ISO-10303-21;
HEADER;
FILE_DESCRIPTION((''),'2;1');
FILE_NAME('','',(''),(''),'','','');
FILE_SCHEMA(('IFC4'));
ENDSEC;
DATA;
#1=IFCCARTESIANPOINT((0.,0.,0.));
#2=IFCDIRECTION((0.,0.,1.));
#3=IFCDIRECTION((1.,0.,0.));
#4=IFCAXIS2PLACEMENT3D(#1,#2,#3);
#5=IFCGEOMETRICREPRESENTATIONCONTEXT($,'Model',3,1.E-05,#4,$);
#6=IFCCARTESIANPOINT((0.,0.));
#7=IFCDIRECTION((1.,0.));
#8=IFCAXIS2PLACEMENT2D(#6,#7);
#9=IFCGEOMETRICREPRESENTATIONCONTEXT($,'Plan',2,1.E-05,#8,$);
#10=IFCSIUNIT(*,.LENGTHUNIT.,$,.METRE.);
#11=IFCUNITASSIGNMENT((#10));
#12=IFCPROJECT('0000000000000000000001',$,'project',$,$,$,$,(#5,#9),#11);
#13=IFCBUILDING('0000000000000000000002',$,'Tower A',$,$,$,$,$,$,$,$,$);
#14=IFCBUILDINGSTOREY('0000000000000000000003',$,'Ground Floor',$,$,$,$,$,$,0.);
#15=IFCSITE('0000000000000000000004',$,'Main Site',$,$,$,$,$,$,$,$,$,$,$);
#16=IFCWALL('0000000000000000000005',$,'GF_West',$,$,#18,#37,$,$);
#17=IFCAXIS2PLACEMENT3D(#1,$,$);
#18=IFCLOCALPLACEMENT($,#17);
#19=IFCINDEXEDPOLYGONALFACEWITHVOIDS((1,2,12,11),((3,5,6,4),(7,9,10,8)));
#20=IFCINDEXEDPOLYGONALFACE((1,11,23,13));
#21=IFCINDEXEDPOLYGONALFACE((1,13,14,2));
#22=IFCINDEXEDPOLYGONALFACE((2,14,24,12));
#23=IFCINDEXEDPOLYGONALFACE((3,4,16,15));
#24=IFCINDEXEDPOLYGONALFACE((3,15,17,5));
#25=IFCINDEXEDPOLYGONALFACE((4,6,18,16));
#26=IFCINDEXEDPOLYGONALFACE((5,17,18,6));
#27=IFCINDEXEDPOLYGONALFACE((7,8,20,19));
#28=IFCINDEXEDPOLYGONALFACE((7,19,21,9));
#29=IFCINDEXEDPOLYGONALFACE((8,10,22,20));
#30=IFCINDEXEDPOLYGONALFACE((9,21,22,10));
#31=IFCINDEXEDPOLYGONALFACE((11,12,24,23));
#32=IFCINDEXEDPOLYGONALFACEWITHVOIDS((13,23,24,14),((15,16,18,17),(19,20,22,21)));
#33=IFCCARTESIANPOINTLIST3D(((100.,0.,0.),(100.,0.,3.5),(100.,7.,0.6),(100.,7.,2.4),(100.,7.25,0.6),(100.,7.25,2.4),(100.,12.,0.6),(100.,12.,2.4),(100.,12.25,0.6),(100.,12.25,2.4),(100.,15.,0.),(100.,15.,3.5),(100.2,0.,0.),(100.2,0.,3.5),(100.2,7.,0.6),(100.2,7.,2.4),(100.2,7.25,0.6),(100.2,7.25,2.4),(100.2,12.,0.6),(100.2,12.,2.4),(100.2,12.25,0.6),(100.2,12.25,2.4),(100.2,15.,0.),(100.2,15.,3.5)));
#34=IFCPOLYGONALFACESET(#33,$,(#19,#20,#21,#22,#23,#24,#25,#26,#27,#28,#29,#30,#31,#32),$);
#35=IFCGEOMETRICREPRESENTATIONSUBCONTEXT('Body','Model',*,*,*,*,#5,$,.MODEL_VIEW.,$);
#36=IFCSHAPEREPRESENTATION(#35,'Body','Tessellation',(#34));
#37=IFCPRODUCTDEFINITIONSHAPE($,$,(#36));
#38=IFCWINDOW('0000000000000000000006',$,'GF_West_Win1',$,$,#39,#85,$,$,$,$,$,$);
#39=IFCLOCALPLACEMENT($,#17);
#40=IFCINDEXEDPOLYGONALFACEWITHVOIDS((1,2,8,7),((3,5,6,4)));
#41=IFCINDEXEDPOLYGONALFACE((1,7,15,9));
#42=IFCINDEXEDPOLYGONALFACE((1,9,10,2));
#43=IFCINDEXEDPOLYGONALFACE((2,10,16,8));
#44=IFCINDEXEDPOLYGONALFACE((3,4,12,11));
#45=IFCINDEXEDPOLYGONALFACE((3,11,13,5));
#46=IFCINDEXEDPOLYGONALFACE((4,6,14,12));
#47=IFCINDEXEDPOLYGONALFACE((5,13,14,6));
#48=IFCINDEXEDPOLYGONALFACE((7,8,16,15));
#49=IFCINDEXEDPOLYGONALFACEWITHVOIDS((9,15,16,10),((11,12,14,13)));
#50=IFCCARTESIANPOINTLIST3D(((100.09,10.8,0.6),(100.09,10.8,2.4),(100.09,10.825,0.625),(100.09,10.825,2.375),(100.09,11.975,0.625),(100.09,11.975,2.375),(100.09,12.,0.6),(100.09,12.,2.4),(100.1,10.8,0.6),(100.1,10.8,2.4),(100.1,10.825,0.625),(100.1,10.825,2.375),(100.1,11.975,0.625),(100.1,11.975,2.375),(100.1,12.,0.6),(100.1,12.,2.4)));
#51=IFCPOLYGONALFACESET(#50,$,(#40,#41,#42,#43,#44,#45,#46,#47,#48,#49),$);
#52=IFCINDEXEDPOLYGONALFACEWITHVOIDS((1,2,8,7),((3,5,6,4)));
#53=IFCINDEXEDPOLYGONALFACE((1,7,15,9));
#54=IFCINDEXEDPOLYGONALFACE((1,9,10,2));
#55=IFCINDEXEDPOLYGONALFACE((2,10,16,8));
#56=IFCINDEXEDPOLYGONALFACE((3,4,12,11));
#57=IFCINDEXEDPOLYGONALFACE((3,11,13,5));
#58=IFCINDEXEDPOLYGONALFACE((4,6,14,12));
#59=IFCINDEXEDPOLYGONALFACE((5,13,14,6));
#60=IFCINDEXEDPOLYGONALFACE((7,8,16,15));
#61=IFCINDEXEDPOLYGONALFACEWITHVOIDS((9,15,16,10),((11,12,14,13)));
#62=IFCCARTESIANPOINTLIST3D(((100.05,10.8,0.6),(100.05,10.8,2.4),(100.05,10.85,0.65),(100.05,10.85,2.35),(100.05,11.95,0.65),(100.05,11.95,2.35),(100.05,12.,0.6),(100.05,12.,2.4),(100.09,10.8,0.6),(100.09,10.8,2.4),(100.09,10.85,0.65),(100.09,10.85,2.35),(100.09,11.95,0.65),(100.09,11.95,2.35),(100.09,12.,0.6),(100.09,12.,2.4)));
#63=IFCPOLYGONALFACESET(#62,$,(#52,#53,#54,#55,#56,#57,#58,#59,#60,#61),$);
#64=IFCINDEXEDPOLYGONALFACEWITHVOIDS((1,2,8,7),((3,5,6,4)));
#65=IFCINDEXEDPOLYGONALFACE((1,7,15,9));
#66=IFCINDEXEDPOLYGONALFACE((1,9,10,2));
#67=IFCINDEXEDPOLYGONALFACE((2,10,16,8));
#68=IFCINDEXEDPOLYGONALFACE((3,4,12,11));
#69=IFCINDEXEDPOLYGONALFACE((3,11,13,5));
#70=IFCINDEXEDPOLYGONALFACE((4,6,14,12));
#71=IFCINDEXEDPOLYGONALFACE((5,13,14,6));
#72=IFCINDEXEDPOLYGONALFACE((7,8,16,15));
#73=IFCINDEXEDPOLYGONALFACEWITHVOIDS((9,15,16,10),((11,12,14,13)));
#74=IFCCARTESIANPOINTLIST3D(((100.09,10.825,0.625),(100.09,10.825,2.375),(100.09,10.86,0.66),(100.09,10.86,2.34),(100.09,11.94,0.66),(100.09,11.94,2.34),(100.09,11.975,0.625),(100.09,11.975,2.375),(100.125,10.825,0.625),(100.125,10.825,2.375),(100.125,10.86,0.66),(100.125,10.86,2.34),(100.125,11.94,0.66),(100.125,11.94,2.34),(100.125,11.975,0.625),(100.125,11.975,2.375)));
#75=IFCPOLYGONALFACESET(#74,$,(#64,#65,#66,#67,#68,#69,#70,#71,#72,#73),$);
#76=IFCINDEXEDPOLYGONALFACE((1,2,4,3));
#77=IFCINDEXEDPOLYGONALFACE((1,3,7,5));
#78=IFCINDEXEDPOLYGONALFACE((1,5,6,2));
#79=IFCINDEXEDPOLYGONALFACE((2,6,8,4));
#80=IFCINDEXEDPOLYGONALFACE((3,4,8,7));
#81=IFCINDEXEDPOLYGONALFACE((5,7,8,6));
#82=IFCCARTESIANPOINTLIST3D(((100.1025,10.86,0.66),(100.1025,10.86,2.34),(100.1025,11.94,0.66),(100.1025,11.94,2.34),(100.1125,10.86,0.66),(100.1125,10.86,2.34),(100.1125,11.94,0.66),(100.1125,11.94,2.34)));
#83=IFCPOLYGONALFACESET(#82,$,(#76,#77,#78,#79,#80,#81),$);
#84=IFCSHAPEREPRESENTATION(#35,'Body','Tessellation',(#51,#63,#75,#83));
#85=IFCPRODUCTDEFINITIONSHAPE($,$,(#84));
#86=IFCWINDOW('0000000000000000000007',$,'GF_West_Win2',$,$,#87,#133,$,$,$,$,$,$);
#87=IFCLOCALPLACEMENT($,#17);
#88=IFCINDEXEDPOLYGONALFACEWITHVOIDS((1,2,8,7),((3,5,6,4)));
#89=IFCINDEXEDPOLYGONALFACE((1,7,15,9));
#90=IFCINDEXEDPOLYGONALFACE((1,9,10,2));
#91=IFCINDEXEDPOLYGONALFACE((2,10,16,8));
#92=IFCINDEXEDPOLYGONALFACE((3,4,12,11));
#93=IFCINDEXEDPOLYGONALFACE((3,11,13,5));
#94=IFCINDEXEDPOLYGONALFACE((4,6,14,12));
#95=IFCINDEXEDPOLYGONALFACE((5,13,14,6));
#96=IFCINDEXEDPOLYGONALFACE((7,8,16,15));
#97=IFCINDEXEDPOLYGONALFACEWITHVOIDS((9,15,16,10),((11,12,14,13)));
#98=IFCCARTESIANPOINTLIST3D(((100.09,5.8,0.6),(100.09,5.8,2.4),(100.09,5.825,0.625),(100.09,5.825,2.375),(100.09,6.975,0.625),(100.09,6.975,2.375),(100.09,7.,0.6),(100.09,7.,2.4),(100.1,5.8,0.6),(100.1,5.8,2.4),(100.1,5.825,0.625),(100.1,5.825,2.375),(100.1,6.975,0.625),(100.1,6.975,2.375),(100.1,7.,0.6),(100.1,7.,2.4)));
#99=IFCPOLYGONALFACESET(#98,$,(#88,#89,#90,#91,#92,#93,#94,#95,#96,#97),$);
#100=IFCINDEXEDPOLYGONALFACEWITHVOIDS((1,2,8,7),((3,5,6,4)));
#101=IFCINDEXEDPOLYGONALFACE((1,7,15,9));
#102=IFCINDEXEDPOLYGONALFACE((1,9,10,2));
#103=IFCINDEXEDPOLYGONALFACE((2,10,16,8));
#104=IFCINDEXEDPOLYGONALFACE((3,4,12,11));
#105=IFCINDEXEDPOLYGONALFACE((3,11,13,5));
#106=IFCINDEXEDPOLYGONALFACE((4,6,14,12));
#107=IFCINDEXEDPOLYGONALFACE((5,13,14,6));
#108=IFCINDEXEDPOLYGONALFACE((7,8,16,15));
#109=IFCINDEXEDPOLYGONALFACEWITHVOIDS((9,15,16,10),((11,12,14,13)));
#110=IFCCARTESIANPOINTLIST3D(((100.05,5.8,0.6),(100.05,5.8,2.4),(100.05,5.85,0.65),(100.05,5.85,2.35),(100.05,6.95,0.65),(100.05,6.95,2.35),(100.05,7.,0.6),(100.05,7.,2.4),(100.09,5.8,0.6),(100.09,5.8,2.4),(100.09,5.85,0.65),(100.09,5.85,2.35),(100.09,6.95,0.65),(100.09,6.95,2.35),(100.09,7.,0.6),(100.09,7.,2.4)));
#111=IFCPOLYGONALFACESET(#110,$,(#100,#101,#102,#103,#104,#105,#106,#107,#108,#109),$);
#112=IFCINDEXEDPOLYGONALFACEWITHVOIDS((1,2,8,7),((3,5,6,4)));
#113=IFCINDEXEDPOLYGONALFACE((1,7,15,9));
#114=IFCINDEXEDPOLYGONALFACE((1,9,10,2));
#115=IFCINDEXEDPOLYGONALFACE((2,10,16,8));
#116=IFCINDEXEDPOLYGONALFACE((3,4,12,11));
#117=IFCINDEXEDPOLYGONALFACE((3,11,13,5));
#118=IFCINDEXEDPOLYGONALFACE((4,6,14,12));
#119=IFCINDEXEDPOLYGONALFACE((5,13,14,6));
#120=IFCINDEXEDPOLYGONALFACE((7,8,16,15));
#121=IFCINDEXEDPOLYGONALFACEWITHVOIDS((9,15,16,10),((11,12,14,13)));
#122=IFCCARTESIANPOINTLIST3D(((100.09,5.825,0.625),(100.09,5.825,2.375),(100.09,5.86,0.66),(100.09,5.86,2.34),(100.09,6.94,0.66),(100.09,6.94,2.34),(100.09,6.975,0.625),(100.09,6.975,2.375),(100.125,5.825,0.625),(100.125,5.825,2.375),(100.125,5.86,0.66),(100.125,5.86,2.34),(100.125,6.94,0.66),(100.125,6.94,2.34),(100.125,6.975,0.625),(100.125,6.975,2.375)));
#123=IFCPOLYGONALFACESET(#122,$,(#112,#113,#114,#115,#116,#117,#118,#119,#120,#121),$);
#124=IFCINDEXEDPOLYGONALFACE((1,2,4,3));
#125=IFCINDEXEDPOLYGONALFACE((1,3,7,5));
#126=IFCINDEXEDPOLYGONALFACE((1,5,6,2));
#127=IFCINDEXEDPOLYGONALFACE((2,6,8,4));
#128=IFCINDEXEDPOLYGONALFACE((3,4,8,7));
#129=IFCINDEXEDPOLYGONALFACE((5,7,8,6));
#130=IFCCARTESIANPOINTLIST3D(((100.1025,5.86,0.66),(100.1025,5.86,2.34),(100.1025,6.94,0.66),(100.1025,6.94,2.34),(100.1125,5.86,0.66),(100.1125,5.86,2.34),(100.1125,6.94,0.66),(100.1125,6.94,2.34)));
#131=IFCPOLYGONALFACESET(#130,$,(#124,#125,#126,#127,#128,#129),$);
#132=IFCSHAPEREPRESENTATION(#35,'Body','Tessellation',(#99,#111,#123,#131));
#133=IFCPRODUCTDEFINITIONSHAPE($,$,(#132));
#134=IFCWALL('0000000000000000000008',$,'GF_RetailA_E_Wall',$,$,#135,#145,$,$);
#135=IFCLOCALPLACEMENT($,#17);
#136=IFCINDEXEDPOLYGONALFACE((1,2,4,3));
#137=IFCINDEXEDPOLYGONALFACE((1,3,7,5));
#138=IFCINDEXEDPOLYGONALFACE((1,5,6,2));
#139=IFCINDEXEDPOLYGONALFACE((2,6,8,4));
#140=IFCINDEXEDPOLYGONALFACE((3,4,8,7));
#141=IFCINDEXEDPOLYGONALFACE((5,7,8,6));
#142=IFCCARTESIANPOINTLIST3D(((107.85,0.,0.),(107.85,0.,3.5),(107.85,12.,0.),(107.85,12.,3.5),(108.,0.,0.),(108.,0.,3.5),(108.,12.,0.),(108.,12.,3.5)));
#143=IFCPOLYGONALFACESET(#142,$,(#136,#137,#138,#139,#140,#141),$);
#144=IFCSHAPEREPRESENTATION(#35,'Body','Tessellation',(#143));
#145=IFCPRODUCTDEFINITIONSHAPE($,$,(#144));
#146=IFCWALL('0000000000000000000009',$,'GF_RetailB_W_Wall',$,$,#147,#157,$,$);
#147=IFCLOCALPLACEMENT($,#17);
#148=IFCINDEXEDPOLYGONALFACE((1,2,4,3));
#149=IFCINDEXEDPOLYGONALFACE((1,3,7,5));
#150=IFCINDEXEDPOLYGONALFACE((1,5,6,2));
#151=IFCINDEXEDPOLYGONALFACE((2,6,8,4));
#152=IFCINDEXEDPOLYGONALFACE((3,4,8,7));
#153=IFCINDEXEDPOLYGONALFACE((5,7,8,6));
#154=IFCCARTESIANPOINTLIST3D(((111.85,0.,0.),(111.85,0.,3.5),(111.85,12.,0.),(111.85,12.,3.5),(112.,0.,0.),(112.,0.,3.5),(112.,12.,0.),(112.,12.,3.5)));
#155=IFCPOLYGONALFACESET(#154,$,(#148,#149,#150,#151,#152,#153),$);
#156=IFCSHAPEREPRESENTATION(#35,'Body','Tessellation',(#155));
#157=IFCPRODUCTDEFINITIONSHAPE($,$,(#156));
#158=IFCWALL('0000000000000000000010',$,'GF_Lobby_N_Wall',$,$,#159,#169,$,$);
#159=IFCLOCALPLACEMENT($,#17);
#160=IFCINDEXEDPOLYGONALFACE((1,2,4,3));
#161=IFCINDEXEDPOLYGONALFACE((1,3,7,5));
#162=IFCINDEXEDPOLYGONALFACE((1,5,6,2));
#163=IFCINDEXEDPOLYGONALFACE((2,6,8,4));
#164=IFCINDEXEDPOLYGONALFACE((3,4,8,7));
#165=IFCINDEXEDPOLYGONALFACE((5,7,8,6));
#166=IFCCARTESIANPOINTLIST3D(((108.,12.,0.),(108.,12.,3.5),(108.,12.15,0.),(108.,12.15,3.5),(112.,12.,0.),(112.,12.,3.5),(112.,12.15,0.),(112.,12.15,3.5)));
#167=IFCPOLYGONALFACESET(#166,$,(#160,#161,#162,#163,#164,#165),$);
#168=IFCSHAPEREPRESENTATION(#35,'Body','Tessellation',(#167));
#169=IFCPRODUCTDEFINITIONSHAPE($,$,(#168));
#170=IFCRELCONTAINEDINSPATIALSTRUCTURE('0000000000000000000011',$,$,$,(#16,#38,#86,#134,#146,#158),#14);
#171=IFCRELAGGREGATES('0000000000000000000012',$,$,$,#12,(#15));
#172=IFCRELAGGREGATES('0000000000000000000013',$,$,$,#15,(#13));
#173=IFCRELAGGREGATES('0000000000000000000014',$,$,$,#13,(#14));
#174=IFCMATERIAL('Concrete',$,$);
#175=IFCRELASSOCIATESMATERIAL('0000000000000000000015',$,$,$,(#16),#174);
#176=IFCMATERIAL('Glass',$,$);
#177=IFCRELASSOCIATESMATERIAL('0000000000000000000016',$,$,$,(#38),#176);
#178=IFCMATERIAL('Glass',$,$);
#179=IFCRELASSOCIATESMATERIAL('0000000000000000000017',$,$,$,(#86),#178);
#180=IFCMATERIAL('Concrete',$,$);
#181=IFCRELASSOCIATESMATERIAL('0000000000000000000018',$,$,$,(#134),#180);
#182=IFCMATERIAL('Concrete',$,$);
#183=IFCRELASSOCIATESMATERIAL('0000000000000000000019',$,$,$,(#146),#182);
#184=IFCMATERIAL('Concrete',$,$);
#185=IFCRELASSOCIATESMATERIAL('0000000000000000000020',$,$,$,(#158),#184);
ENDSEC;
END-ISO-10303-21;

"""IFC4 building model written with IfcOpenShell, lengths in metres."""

from ifc_helpers import new_model, si_unit, frame, origin_with_axes, origin_2d_with_axis, place, context, subcontext, project, spatial, line, indexed_curve, outline, extrude, material, element, fill, save


model = new_model("IFC4")

# Units and contexts
model_context = context("Model", 3, precision=1e-05, world=origin_with_axes())
plan_context = context("Plan", 2, precision=1e-05, world=origin_2d_with_axis())
body_context = subcontext(model_context, "Body", "Model", "MODEL_VIEW")
ifc_project = project(units=[si_unit("LENGTHUNIT", "METRE")], contexts=[model_context, plan_context])

# Site, building, storey
site = spatial("IfcSite", under=ifc_project, Name="Main Site")
building = spatial("IfcBuilding", under=site, Name="Tower A")
storey = spatial("IfcBuildingStorey", under=building, Name="Ground Floor", Elevation=0.0)

# Wall, openings, windows
ifc_material_1 = material(Name="Concrete")
wall_1_placement = place(None, frame((100.0, 15.0, 0.0), z_axis=(0.0, 0.0, 1.0), x_axis=(0.0, -1.0, 0.0)))
wall_1 = element("IfcWall", 1, at=wall_1_placement, inside=storey, material=ifc_material_1, Name="GF_West", context=body_context, shape_type="SweptSolid", body=[
    extrude(outline(indexed_curve([(0.0, 0.0), (0.0, 0.2), (15.0, 0.2), (15.0, 0.0), (0.0, 0.0)], self_intersect=False)), origin_with_axes(), (0.0, 0.0, 1.0), 3.5),
])
opening_1_placement = place(wall_1_placement, frame((3.0, 0.0, 0.6), z_axis=(0.0, 0.0, 1.0), x_axis=(0.0, 1.0, 0.0)))
opening_1 = element("IfcOpeningElement", 2, at=opening_1_placement, cuts=wall_1, context=body_context, shape_type="SweptSolid", body=[
    extrude(outline(indexed_curve([(0.0, 0.0), (0.0, 0.25), (1.2, 0.25), (1.2, 0.0), (0.0, 0.0)], self_intersect=False)), origin_with_axes(), (0.0, 0.0, 1.0), 1.8),
])
opening_2_placement = place(wall_1_placement, frame((8.0, 0.0, 0.6), z_axis=(0.0, 0.0, 1.0), x_axis=(0.0, 1.0, 0.0)))
opening_2 = element("IfcOpeningElement", 3, at=opening_2_placement, cuts=wall_1, context=body_context, shape_type="SweptSolid", body=[
    extrude(outline(indexed_curve([(0.0, 0.0), (0.0, 0.25), (1.2, 0.25), (1.2, 0.0), (0.0, 0.0)], self_intersect=False)), origin_with_axes(), (0.0, 0.0, 1.0), 1.8),
])
ifc_material_2 = material(Name="Glass")
window_1_placement = place(None, frame((100.0, 12.0, 0.6), z_axis=(0.0, 0.0, 1.0), x_axis=(0.0, -1.0, 0.0)))
window_1 = element("IfcWindow", 4, at=window_1_placement, inside=storey, material=ifc_material_2, Name="GF_West_Win1", context=body_context, shape_type="SweptSolid", body=[
    extrude(outline(indexed_curve([(0.0, 0.0), (1.2, 0.0), (1.2, 1.8), (0.0, 1.8)], segments=[line(1, 2, 3, 4, 1)]), holes=[indexed_curve([(0.025, 0.025), (1.175, 0.025), (1.175, 1.775), (0.025, 1.775)], segments=[line(1, 2, 3, 4, 1)])]), frame((0.0, 0.09, 0.0), z_axis=(0.0, -1.0, 0.0), x_axis=(1.0, 0.0, 0.0)), (0.0, 0.0, -1.0), 0.01),
    extrude(outline(indexed_curve([(0.0, 0.0), (1.2, 0.0), (1.2, 1.8), (0.0, 1.8)], segments=[line(1, 2, 3, 4, 1)]), holes=[indexed_curve([(0.05, 0.05), (1.15, 0.05), (1.15, 1.75), (0.05, 1.75)], segments=[line(1, 2, 3, 4, 1)])]), frame((0.0, 0.05, 0.0), z_axis=(0.0, -1.0, 0.0), x_axis=(1.0, 0.0, 0.0)), (0.0, 0.0, -1.0), 0.04),
    extrude(outline(indexed_curve([(0.0, 0.0), (1.15, 0.0), (1.15, 1.75), (0.0, 1.75)], segments=[line(1, 2, 3, 4, 1)]), holes=[indexed_curve([(0.035, 0.035), (1.115, 0.035), (1.115, 1.715), (0.035, 1.715)], segments=[line(1, 2, 3, 4, 1)])]), frame((0.025, 0.09, 0.025), z_axis=(0.0, -1.0, 0.0), x_axis=(1.0, 0.0, 0.0)), (0.0, 0.0, -1.0), 0.035),
    extrude(outline(indexed_curve([(0.035, 0.035), (1.115, 0.035), (1.115, 1.715), (0.035, 1.715)], segments=[line(1, 2, 3, 4, 1)])), frame((0.025, 0.1025, 0.025), z_axis=(0.0, -1.0, 0.0), x_axis=(1.0, 0.0, 0.0)), (0.0, 0.0, -1.0), 0.01),
])
fill(opening_1, window_1)
ifc_material_3 = material(Name="Glass")
window_2_placement = place(None, frame((100.0, 7.0, 0.6), z_axis=(0.0, 0.0, 1.0), x_axis=(0.0, -1.0, 0.0)))
window_2 = element("IfcWindow", 5, at=window_2_placement, inside=storey, material=ifc_material_3, Name="GF_West_Win2", context=body_context, shape_type="SweptSolid", body=[
    extrude(outline(indexed_curve([(0.0, 0.0), (1.2, 0.0), (1.2, 1.8), (0.0, 1.8)], segments=[line(1, 2, 3, 4, 1)]), holes=[indexed_curve([(0.025, 0.025), (1.175, 0.025), (1.175, 1.775), (0.025, 1.775)], segments=[line(1, 2, 3, 4, 1)])]), frame((0.0, 0.09, 0.0), z_axis=(0.0, -1.0, 0.0), x_axis=(1.0, 0.0, 0.0)), (0.0, 0.0, -1.0), 0.01),
    extrude(outline(indexed_curve([(0.0, 0.0), (1.2, 0.0), (1.2, 1.8), (0.0, 1.8)], segments=[line(1, 2, 3, 4, 1)]), holes=[indexed_curve([(0.05, 0.05), (1.15, 0.05), (1.15, 1.75), (0.05, 1.75)], segments=[line(1, 2, 3, 4, 1)])]), frame((0.0, 0.05, 0.0), z_axis=(0.0, -1.0, 0.0), x_axis=(1.0, 0.0, 0.0)), (0.0, 0.0, -1.0), 0.04),
    extrude(outline(indexed_curve([(0.0, 0.0), (1.15, 0.0), (1.15, 1.75), (0.0, 1.75)], segments=[line(1, 2, 3, 4, 1)]), holes=[indexed_curve([(0.035, 0.035), (1.115, 0.035), (1.115, 1.715), (0.035, 1.715)], segments=[line(1, 2, 3, 4, 1)])]), frame((0.025, 0.09, 0.025), z_axis=(0.0, -1.0, 0.0), x_axis=(1.0, 0.0, 0.0)), (0.0, 0.0, -1.0), 0.035),
    extrude(outline(indexed_curve([(0.035, 0.035), (1.115, 0.035), (1.115, 1.715), (0.035, 1.715)], segments=[line(1, 2, 3, 4, 1)])), frame((0.025, 0.1025, 0.025), z_axis=(0.0, -1.0, 0.0), x_axis=(1.0, 0.0, 0.0)), (0.0, 0.0, -1.0), 0.01),
])
fill(opening_2, window_2)

# Walls
ifc_material_4 = material(Name="Concrete")
wall_2_placement = place(None, frame((108.0, 0.0, 0.0), z_axis=(0.0, 0.0, 1.0), x_axis=(0.0, 1.0, 0.0)))
element("IfcWall", 6, at=wall_2_placement, inside=storey, material=ifc_material_4, Name="GF_RetailA_E_Wall", context=body_context, shape_type="SweptSolid", body=[
    extrude(outline(indexed_curve([(0.0, 0.0), (0.0, 0.15), (12.0, 0.15), (12.0, 0.0), (0.0, 0.0)], self_intersect=False)), origin_with_axes(), (0.0, 0.0, 1.0), 3.5),
])
ifc_material_5 = material(Name="Concrete")
wall_3_placement = place(None, frame((112.0, 0.0, 0.0), z_axis=(0.0, 0.0, 1.0), x_axis=(0.0, 1.0, 0.0)))
element("IfcWall", 7, at=wall_3_placement, inside=storey, material=ifc_material_5, Name="GF_RetailB_W_Wall", context=body_context, shape_type="SweptSolid", body=[
    extrude(outline(indexed_curve([(0.0, 0.0), (0.0, 0.15), (12.0, 0.15), (12.0, 0.0), (0.0, 0.0)], self_intersect=False)), origin_with_axes(), (0.0, 0.0, 1.0), 3.5),
])
ifc_material_6 = material(Name="Concrete")
wall_4_placement = place(None, frame((108.0, 12.0, 0.0), z_axis=(0.0, 0.0, 1.0), x_axis=(1.0, 0.0, 0.0)))
element("IfcWall", 8, at=wall_4_placement, inside=storey, material=ifc_material_6, Name="GF_Lobby_N_Wall", context=body_context, shape_type="SweptSolid", body=[
    extrude(outline(indexed_curve([(0.0, 0.0), (0.0, 0.15), (4.0, 0.15), (4.0, 0.0), (0.0, 0.0)], self_intersect=False)), origin_with_axes(), (0.0, 0.0, 1.0), 3.5),
])

save(model, "model.ifc")
